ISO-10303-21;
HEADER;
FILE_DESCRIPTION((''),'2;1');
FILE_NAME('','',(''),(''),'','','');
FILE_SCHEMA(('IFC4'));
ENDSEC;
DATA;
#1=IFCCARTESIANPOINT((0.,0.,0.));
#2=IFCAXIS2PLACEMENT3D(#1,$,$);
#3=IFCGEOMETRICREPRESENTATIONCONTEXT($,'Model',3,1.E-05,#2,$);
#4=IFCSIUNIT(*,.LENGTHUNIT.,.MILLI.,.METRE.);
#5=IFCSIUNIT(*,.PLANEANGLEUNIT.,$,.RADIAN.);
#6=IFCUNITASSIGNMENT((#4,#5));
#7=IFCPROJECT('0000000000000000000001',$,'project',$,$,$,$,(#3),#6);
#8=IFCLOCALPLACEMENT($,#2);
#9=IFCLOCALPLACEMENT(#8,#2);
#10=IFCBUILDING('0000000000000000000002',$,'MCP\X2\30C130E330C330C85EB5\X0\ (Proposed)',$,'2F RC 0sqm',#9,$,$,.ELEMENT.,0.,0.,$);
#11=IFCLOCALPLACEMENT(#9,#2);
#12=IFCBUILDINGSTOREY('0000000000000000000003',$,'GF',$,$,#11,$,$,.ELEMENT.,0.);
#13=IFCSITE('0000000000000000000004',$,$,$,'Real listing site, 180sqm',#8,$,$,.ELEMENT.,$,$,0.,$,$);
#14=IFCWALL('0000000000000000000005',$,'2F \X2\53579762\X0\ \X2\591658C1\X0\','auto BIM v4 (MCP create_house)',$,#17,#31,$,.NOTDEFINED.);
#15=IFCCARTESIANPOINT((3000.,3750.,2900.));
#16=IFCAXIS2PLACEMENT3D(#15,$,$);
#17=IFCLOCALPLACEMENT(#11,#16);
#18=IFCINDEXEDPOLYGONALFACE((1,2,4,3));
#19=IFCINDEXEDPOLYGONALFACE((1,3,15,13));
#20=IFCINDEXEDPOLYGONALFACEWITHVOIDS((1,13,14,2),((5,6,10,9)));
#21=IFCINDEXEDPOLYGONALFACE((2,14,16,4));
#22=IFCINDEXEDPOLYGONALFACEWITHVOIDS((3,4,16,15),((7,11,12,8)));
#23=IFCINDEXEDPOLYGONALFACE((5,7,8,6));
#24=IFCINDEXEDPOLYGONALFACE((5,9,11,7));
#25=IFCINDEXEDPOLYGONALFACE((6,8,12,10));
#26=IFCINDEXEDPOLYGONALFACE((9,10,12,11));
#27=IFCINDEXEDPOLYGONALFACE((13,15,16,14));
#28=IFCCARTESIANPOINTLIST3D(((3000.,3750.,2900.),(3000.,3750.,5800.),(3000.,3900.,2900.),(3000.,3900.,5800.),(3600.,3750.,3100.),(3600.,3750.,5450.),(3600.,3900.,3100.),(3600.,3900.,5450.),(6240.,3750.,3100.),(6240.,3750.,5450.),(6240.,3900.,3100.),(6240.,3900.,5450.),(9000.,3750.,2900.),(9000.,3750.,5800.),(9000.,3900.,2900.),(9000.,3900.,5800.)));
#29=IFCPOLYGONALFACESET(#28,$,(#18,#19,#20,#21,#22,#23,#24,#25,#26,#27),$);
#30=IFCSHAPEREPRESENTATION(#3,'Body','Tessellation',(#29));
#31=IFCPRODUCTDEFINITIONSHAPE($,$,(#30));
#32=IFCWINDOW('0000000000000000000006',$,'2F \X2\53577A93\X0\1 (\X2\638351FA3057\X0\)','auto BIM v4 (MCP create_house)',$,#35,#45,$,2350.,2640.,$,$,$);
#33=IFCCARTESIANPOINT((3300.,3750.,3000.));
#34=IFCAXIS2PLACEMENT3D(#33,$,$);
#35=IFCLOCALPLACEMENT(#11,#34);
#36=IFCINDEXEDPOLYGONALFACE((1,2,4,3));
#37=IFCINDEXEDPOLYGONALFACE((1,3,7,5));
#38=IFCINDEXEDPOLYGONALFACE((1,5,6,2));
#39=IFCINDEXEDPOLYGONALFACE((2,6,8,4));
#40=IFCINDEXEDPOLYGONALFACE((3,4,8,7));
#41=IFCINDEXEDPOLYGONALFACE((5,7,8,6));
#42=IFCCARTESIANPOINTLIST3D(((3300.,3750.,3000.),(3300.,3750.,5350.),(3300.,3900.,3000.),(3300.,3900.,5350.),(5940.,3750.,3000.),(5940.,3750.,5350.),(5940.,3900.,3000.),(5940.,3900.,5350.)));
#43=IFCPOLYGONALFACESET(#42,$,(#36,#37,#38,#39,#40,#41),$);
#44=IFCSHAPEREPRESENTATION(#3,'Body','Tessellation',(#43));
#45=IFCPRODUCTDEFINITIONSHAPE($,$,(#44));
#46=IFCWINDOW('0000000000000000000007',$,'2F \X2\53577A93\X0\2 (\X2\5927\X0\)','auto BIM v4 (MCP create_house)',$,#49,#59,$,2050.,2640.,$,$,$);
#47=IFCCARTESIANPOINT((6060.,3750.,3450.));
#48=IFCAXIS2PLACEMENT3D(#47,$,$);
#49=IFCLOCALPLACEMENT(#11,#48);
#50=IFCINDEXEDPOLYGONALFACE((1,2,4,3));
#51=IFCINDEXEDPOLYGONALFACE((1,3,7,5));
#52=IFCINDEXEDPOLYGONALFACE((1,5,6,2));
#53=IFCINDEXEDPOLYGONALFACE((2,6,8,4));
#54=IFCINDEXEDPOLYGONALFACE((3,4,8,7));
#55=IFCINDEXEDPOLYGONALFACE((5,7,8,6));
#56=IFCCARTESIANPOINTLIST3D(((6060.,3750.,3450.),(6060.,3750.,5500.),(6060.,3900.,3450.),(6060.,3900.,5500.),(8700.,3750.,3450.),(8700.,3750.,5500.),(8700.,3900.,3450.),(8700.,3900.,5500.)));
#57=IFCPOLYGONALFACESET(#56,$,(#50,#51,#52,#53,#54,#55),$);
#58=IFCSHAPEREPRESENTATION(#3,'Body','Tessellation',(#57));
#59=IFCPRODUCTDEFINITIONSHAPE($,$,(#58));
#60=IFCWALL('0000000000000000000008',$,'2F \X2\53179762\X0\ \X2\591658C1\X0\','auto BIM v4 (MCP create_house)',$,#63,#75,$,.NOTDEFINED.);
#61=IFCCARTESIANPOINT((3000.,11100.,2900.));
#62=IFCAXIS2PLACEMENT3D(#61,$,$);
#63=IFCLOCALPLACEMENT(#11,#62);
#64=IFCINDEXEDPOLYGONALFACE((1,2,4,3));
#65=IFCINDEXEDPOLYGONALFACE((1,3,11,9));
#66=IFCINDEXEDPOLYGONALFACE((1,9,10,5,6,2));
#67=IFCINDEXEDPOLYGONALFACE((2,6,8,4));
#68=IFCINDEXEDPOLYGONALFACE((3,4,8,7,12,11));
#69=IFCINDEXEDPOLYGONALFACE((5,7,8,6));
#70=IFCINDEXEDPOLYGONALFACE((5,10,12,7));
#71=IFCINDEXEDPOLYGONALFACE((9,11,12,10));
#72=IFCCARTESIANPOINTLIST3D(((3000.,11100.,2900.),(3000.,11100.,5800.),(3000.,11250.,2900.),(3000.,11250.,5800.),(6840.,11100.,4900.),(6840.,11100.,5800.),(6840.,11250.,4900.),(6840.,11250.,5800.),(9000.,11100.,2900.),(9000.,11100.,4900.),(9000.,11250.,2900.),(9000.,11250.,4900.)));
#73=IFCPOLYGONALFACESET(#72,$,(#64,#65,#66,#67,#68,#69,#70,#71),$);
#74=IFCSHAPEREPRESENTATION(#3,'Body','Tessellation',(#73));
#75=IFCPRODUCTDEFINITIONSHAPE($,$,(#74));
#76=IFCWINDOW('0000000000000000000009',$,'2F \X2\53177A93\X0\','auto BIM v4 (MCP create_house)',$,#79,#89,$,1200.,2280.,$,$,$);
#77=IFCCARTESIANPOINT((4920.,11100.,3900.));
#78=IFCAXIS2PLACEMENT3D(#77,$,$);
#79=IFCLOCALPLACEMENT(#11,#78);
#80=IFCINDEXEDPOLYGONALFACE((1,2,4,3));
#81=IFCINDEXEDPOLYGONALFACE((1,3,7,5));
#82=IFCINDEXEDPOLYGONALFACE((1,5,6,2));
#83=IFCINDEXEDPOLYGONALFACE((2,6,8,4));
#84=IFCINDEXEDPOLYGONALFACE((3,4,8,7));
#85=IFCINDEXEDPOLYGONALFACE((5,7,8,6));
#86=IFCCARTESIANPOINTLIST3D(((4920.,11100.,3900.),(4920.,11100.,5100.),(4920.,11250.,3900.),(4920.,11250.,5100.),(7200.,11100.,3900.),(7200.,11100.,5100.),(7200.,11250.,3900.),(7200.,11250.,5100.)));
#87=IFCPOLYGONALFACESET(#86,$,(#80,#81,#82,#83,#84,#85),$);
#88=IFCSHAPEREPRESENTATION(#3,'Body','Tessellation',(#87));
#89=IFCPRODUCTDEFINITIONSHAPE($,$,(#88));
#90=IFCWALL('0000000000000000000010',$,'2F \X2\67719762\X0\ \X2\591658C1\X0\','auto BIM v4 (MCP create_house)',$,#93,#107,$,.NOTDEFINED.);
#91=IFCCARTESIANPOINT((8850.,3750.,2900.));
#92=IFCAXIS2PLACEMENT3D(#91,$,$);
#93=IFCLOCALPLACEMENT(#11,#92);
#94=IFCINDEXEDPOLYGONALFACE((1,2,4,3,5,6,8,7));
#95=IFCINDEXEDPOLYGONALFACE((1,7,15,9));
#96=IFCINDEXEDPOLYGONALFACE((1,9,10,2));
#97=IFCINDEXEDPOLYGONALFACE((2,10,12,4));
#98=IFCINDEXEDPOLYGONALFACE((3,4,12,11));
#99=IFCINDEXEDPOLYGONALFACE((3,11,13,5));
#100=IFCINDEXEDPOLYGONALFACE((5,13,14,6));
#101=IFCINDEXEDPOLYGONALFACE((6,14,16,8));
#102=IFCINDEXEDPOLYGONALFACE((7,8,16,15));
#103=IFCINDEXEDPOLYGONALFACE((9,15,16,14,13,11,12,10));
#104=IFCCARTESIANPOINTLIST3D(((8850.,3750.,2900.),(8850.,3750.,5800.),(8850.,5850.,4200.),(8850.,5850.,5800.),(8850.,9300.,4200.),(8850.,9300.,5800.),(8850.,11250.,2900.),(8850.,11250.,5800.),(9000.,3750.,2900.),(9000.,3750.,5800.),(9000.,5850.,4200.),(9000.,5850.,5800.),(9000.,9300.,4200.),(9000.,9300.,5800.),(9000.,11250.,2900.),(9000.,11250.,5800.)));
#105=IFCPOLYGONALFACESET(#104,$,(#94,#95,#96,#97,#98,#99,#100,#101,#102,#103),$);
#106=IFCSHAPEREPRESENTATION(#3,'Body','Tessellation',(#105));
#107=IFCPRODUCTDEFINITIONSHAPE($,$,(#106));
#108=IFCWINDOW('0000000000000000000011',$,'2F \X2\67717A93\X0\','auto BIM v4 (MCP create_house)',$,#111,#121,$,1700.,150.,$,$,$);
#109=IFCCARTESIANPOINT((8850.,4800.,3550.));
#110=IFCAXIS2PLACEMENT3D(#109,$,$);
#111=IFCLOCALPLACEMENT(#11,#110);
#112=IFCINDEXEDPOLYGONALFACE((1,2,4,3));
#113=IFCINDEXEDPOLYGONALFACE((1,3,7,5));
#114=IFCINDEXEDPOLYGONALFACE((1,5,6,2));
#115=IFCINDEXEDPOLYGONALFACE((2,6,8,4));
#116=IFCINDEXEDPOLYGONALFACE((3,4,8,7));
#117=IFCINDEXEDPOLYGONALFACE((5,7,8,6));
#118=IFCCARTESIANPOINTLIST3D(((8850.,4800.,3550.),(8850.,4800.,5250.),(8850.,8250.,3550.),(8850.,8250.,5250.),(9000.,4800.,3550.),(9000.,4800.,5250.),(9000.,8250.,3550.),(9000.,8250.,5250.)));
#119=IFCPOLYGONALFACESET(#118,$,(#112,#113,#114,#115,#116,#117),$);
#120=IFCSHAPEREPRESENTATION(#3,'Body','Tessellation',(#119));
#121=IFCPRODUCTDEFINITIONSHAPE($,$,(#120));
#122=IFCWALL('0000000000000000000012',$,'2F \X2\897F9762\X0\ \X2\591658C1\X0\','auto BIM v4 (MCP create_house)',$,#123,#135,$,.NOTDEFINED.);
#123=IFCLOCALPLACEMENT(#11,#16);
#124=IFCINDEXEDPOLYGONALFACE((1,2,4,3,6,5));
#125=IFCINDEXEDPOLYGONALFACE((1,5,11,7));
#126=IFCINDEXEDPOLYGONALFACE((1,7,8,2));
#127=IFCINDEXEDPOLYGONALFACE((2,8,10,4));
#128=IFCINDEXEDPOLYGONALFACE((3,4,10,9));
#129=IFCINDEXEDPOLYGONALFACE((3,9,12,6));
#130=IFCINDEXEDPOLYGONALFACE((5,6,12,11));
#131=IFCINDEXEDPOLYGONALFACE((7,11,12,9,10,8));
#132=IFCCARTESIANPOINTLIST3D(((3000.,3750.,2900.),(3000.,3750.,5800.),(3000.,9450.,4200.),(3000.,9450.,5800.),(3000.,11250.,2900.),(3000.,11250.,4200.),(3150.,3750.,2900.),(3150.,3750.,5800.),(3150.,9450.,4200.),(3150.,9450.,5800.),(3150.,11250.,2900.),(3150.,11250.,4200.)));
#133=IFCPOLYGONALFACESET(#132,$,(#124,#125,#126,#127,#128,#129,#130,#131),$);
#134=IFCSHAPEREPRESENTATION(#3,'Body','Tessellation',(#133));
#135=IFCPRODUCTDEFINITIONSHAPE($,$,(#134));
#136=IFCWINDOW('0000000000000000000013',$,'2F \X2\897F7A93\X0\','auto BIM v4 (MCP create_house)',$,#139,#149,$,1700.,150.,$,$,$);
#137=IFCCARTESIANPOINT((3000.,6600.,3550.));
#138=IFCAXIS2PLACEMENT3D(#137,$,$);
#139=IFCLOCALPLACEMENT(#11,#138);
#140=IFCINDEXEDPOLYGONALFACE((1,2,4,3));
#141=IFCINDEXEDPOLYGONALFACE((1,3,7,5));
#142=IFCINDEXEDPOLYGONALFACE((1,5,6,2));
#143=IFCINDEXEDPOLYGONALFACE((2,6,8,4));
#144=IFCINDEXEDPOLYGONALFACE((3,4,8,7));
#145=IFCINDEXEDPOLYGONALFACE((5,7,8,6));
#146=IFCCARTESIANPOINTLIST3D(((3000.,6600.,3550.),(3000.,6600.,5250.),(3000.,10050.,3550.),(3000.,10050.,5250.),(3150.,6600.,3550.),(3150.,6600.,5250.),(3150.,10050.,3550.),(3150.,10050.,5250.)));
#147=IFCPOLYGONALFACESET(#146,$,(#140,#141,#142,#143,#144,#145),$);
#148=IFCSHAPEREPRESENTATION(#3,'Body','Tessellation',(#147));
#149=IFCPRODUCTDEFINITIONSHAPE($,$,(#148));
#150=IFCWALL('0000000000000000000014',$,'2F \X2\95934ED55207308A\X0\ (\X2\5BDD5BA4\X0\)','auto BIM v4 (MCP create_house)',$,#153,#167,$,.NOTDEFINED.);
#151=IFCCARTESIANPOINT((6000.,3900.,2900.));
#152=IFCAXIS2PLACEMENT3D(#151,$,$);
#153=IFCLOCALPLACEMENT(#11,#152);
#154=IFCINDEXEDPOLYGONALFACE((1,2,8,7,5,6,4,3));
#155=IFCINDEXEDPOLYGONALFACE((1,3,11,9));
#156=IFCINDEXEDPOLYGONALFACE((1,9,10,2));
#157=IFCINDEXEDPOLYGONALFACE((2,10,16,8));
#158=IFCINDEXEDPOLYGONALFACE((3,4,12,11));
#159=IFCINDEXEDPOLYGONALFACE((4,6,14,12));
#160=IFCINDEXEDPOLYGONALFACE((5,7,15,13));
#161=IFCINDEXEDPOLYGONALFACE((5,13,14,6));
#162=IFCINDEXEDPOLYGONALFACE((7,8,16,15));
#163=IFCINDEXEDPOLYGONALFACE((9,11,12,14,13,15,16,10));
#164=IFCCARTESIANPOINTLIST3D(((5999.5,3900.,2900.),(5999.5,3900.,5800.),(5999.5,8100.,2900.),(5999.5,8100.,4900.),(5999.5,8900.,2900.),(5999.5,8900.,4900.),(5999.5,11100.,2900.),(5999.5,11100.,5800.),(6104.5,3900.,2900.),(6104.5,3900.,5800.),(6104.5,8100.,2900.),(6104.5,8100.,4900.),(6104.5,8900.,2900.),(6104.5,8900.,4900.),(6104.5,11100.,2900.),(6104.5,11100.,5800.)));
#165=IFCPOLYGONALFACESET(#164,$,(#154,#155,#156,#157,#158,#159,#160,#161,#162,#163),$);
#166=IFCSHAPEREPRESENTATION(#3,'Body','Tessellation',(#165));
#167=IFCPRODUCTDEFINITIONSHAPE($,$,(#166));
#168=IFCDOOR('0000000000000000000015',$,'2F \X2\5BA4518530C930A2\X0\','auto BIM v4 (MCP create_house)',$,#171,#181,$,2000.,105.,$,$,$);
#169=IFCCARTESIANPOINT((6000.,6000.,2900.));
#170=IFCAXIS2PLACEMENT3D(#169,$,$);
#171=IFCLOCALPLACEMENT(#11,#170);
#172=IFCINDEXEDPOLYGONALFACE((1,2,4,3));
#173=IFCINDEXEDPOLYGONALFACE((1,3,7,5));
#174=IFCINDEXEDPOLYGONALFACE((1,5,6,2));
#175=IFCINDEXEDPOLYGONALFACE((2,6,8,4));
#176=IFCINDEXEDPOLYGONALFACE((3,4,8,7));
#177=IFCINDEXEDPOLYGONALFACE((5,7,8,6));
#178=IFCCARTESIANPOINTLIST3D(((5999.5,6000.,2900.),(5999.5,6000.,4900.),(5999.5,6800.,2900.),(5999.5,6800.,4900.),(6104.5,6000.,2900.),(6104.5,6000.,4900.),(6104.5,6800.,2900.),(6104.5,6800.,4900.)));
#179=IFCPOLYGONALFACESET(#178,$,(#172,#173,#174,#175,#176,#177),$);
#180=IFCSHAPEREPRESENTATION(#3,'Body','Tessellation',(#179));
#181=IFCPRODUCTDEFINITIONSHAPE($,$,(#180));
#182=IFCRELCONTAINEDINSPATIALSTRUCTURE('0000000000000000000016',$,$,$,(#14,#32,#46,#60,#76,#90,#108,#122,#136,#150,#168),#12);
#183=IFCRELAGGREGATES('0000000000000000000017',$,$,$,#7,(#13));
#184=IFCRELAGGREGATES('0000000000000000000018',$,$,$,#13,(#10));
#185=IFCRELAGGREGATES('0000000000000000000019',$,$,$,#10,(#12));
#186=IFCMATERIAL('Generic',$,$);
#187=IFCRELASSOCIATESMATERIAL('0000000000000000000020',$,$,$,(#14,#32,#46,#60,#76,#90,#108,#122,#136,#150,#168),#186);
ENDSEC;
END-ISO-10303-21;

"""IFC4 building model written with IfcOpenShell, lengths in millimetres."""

from ifc_helpers import new_model, si_unit, frame, frame_2d, origin, place, context, project, spatial, rectangle, extrude, material, element, fill, save


model = new_model("IFC4")

# Units and contexts
model_context = context("Model", 3, precision=1e-05, world=origin())
ifc_project = project(units=[si_unit("LENGTHUNIT", "METRE", prefix="MILLI"), si_unit("PLANEANGLEUNIT", "RADIAN")], contexts=[model_context])

# Site, building, storey
site_placement = place(None, origin())
site = spatial("IfcSite", under=ifc_project, at=site_placement, ObjectType="Real listing site, 180sqm", CompositionType="ELEMENT", RefElevation=0.0)
building_placement = place(site_placement, origin())
building = spatial("IfcBuilding", under=site, at=building_placement, Name="MCPチャット庵 (Proposed)", ObjectType="2F RC 0sqm", CompositionType="ELEMENT", ElevationOfRefHeight=0.0, ElevationOfTerrain=0.0)
storey_placement = place(building_placement, origin())
storey = spatial("IfcBuildingStorey", under=building, at=storey_placement, Name="GF", CompositionType="ELEMENT", Elevation=0.0)

# Shared definitions
ifc_material = material(Name="Generic")

# Wall, openings, windows
wall_1_placement = place(storey_placement, frame((3000.0, 3750.0, 2900.0)))
wall_1 = element("IfcWall", 1, at=wall_1_placement, inside=storey, material=ifc_material, Name="2F 南面 外壁", Description="auto BIM v4 (MCP create_house)", PredefinedType="NOTDEFINED", context=model_context, shape_type="SweptSolid", body=[
    extrude(rectangle(XDim=6000.0, YDim=150.0, at=frame_2d((3000.0, 75.0))), frame((3000.0, 3750.0, 2900.0)), (0.0, 0.0, 1.0), 2900.0),
])
opening_1_placement = place(storey_placement, frame((3300.0, 3750.0, 3000.0)))
opening_1 = element("IfcOpeningElement", 2, at=opening_1_placement, cuts=wall_1, PredefinedType="NOTDEFINED", context=model_context, shape_type="SweptSolid", body=[
    extrude(rectangle(XDim=2640.0, YDim=150.0, at=frame_2d((1320.0, 75.0))), frame((3300.0, 3750.0, 3000.0)), (0.0, 0.0, 1.0), 2350.0),
])
opening_2_placement = place(storey_placement, frame((6060.0, 3750.0, 3450.0)))
opening_2 = element("IfcOpeningElement", 3, at=opening_2_placement, cuts=wall_1, PredefinedType="NOTDEFINED", context=model_context, shape_type="SweptSolid", body=[
    extrude(rectangle(XDim=2640.0, YDim=150.0, at=frame_2d((1320.0, 75.0))), frame((6060.0, 3750.0, 3450.0)), (0.0, 0.0, 1.0), 2050.0),
])
window_1_placement = place(storey_placement, frame((3300.0, 3750.0, 3000.0)))
window_1 = element("IfcWindow", 4, at=window_1_placement, inside=storey, material=ifc_material, Name="2F 南窓1 (掃出し)", Description="auto BIM v4 (MCP create_house)", OverallHeight=2350.0, OverallWidth=2640.0, context=model_context, shape_type="SweptSolid", body=[
    extrude(rectangle(XDim=2640.0, YDim=150.0, at=frame_2d((1320.0, 75.0))), frame((3300.0, 3750.0, 3000.0)), (0.0, 0.0, 1.0), 2350.0),
])
fill(opening_1, window_1)
window_2_placement = place(storey_placement, frame((6060.0, 3750.0, 3450.0)))
window_2 = element("IfcWindow", 5, at=window_2_placement, inside=storey, material=ifc_material, Name="2F 南窓2 (大)", Description="auto BIM v4 (MCP create_house)", OverallHeight=2050.0, OverallWidth=2640.0, context=model_context, shape_type="SweptSolid", body=[
    extrude(rectangle(XDim=2640.0, YDim=150.0, at=frame_2d((1320.0, 75.0))), frame((6060.0, 3750.0, 3450.0)), (0.0, 0.0, 1.0), 2050.0),
])
fill(opening_2, window_2)

# Walls, openings, windows
wall_2_placement = place(storey_placement, frame((3000.0, 11100.0, 2900.0)))
wall_2 = element("IfcWall", 6, at=wall_2_placement, inside=storey, material=ifc_material, Name="2F 北面 外壁", Description="auto BIM v4 (MCP create_house)", PredefinedType="NOTDEFINED", context=model_context, shape_type="SweptSolid", body=[
    extrude(rectangle(XDim=6000.0, YDim=150.0, at=frame_2d((3000.0, 75.0))), frame((3000.0, 11100.0, 2900.0)), (0.0, 0.0, 1.0), 2900.0),
])
opening_3_placement = place(storey_placement, frame((4920.0, 11100.0, 3900.0)))
opening_3 = element("IfcOpeningElement", 7, at=opening_3_placement, cuts=wall_2, PredefinedType="NOTDEFINED", context=model_context, shape_type="SweptSolid", body=[
    extrude(rectangle(XDim=2280.0, YDim=150.0, at=frame_2d((1140.0, 75.0))), frame((4920.0, 11100.0, 3900.0)), (0.0, 0.0, 1.0), 1200.0),
])
window_3_placement = place(storey_placement, frame((4920.0, 11100.0, 3900.0)))
window_3 = element("IfcWindow", 8, at=window_3_placement, inside=storey, material=ifc_material, Name="2F 北窓", Description="auto BIM v4 (MCP create_house)", OverallHeight=1200.0, OverallWidth=2280.0, context=model_context, shape_type="SweptSolid", body=[
    extrude(rectangle(XDim=2280.0, YDim=150.0, at=frame_2d((1140.0, 75.0))), frame((4920.0, 11100.0, 3900.0)), (0.0, 0.0, 1.0), 1200.0),
])
fill(opening_3, window_3)
wall_3_placement = place(storey_placement, frame((8850.0, 3750.0, 2900.0)))
wall_3 = element("IfcWall", 9, at=wall_3_placement, inside=storey, material=ifc_material, Name="2F 東面 外壁", Description="auto BIM v4 (MCP create_house)", PredefinedType="NOTDEFINED", context=model_context, shape_type="SweptSolid", body=[
    extrude(rectangle(XDim=150.0, YDim=7500.0, at=frame_2d((75.0, 3750.0))), frame((8850.0, 3750.0, 2900.0)), (0.0, 0.0, 1.0), 2900.0),
])
opening_4_placement = place(storey_placement, frame((8850.0, 4800.0, 3550.0)))
opening_4 = element("IfcOpeningElement", 10, at=opening_4_placement, cuts=wall_3, PredefinedType="NOTDEFINED", context=model_context, shape_type="SweptSolid", body=[
    extrude(rectangle(XDim=150.0, YDim=3450.0, at=frame_2d((75.0, 1725.0))), frame((8850.0, 4800.0, 3550.0)), (0.0, 0.0, 1.0), 1700.0),
])
window_4_placement = place(storey_placement, frame((8850.0, 4800.0, 3550.0)))
window_4 = element("IfcWindow", 11, at=window_4_placement, inside=storey, material=ifc_material, Name="2F 東窓", Description="auto BIM v4 (MCP create_house)", OverallHeight=1700.0, OverallWidth=150.0, context=model_context, shape_type="SweptSolid", body=[
    extrude(rectangle(XDim=150.0, YDim=3450.0, at=frame_2d((75.0, 1725.0))), frame((8850.0, 4800.0, 3550.0)), (0.0, 0.0, 1.0), 1700.0),
])
fill(opening_4, window_4)
wall_4_placement = place(storey_placement, frame((3000.0, 3750.0, 2900.0)))
wall_4 = element("IfcWall", 12, at=wall_4_placement, inside=storey, material=ifc_material, Name="2F 西面 外壁", Description="auto BIM v4 (MCP create_house)", PredefinedType="NOTDEFINED", context=model_context, shape_type="SweptSolid", body=[
    extrude(rectangle(XDim=150.0, YDim=7500.0, at=frame_2d((75.0, 3750.0))), frame((3000.0, 3750.0, 2900.0)), (0.0, 0.0, 1.0), 2900.0),
])
opening_5_placement = place(storey_placement, frame((3000.0, 6600.0, 3550.0)))
opening_5 = element("IfcOpeningElement", 13, at=opening_5_placement, cuts=wall_4, PredefinedType="NOTDEFINED", context=model_context, shape_type="SweptSolid", body=[
    extrude(rectangle(XDim=150.0, YDim=3450.0, at=frame_2d((75.0, 1725.0))), frame((3000.0, 6600.0, 3550.0)), (0.0, 0.0, 1.0), 1700.0),
])
window_5_placement = place(storey_placement, frame((3000.0, 6600.0, 3550.0)))
window_5 = element("IfcWindow", 14, at=window_5_placement, inside=storey, material=ifc_material, Name="2F 西窓", Description="auto BIM v4 (MCP create_house)", OverallHeight=1700.0, OverallWidth=150.0, context=model_context, shape_type="SweptSolid", body=[
    extrude(rectangle(XDim=150.0, YDim=3450.0, at=frame_2d((75.0, 1725.0))), frame((3000.0, 6600.0, 3550.0)), (0.0, 0.0, 1.0), 1700.0),
])
fill(opening_5, window_5)

# Wall, opening, door
wall_5_placement = place(storey_placement, frame((6000.0, 3900.0, 2900.0)))
wall_5 = element("IfcWall", 15, at=wall_5_placement, inside=storey, material=ifc_material, Name="2F 間仕切り (寝室)", Description="auto BIM v4 (MCP create_house)", PredefinedType="NOTDEFINED", context=model_context, shape_type="SweptSolid", body=[
    extrude(rectangle(XDim=105.0, YDim=7200.0, at=frame_2d((52.0, 3600.0))), frame((6000.0, 3900.0, 2900.0)), (0.0, 0.0, 1.0), 2900.0),
])
opening_6_placement = place(storey_placement, frame((6000.0, 6000.0, 2900.0)))
opening_6 = element("IfcOpeningElement", 16, at=opening_6_placement, cuts=wall_5, PredefinedType="NOTDEFINED", context=model_context, shape_type="SweptSolid", body=[
    extrude(rectangle(XDim=105.0, YDim=800.0, at=frame_2d((52.0, 400.0))), frame((6000.0, 6000.0, 2900.0)), (0.0, 0.0, 1.0), 2000.0),
])
door_1_placement = place(storey_placement, frame((6000.0, 6000.0, 2900.0)))
door_1 = element("IfcDoor", 17, at=door_1_placement, inside=storey, material=ifc_material, Name="2F 室内ドア", Description="auto BIM v4 (MCP create_house)", OverallHeight=2000.0, OverallWidth=105.0, context=model_context, shape_type="SweptSolid", body=[
    extrude(rectangle(XDim=105.0, YDim=800.0, at=frame_2d((52.0, 400.0))), frame((6000.0, 6000.0, 2900.0)), (0.0, 0.0, 1.0), 2000.0),
])
fill(opening_6, door_1)

save(model, "model.ifc")
